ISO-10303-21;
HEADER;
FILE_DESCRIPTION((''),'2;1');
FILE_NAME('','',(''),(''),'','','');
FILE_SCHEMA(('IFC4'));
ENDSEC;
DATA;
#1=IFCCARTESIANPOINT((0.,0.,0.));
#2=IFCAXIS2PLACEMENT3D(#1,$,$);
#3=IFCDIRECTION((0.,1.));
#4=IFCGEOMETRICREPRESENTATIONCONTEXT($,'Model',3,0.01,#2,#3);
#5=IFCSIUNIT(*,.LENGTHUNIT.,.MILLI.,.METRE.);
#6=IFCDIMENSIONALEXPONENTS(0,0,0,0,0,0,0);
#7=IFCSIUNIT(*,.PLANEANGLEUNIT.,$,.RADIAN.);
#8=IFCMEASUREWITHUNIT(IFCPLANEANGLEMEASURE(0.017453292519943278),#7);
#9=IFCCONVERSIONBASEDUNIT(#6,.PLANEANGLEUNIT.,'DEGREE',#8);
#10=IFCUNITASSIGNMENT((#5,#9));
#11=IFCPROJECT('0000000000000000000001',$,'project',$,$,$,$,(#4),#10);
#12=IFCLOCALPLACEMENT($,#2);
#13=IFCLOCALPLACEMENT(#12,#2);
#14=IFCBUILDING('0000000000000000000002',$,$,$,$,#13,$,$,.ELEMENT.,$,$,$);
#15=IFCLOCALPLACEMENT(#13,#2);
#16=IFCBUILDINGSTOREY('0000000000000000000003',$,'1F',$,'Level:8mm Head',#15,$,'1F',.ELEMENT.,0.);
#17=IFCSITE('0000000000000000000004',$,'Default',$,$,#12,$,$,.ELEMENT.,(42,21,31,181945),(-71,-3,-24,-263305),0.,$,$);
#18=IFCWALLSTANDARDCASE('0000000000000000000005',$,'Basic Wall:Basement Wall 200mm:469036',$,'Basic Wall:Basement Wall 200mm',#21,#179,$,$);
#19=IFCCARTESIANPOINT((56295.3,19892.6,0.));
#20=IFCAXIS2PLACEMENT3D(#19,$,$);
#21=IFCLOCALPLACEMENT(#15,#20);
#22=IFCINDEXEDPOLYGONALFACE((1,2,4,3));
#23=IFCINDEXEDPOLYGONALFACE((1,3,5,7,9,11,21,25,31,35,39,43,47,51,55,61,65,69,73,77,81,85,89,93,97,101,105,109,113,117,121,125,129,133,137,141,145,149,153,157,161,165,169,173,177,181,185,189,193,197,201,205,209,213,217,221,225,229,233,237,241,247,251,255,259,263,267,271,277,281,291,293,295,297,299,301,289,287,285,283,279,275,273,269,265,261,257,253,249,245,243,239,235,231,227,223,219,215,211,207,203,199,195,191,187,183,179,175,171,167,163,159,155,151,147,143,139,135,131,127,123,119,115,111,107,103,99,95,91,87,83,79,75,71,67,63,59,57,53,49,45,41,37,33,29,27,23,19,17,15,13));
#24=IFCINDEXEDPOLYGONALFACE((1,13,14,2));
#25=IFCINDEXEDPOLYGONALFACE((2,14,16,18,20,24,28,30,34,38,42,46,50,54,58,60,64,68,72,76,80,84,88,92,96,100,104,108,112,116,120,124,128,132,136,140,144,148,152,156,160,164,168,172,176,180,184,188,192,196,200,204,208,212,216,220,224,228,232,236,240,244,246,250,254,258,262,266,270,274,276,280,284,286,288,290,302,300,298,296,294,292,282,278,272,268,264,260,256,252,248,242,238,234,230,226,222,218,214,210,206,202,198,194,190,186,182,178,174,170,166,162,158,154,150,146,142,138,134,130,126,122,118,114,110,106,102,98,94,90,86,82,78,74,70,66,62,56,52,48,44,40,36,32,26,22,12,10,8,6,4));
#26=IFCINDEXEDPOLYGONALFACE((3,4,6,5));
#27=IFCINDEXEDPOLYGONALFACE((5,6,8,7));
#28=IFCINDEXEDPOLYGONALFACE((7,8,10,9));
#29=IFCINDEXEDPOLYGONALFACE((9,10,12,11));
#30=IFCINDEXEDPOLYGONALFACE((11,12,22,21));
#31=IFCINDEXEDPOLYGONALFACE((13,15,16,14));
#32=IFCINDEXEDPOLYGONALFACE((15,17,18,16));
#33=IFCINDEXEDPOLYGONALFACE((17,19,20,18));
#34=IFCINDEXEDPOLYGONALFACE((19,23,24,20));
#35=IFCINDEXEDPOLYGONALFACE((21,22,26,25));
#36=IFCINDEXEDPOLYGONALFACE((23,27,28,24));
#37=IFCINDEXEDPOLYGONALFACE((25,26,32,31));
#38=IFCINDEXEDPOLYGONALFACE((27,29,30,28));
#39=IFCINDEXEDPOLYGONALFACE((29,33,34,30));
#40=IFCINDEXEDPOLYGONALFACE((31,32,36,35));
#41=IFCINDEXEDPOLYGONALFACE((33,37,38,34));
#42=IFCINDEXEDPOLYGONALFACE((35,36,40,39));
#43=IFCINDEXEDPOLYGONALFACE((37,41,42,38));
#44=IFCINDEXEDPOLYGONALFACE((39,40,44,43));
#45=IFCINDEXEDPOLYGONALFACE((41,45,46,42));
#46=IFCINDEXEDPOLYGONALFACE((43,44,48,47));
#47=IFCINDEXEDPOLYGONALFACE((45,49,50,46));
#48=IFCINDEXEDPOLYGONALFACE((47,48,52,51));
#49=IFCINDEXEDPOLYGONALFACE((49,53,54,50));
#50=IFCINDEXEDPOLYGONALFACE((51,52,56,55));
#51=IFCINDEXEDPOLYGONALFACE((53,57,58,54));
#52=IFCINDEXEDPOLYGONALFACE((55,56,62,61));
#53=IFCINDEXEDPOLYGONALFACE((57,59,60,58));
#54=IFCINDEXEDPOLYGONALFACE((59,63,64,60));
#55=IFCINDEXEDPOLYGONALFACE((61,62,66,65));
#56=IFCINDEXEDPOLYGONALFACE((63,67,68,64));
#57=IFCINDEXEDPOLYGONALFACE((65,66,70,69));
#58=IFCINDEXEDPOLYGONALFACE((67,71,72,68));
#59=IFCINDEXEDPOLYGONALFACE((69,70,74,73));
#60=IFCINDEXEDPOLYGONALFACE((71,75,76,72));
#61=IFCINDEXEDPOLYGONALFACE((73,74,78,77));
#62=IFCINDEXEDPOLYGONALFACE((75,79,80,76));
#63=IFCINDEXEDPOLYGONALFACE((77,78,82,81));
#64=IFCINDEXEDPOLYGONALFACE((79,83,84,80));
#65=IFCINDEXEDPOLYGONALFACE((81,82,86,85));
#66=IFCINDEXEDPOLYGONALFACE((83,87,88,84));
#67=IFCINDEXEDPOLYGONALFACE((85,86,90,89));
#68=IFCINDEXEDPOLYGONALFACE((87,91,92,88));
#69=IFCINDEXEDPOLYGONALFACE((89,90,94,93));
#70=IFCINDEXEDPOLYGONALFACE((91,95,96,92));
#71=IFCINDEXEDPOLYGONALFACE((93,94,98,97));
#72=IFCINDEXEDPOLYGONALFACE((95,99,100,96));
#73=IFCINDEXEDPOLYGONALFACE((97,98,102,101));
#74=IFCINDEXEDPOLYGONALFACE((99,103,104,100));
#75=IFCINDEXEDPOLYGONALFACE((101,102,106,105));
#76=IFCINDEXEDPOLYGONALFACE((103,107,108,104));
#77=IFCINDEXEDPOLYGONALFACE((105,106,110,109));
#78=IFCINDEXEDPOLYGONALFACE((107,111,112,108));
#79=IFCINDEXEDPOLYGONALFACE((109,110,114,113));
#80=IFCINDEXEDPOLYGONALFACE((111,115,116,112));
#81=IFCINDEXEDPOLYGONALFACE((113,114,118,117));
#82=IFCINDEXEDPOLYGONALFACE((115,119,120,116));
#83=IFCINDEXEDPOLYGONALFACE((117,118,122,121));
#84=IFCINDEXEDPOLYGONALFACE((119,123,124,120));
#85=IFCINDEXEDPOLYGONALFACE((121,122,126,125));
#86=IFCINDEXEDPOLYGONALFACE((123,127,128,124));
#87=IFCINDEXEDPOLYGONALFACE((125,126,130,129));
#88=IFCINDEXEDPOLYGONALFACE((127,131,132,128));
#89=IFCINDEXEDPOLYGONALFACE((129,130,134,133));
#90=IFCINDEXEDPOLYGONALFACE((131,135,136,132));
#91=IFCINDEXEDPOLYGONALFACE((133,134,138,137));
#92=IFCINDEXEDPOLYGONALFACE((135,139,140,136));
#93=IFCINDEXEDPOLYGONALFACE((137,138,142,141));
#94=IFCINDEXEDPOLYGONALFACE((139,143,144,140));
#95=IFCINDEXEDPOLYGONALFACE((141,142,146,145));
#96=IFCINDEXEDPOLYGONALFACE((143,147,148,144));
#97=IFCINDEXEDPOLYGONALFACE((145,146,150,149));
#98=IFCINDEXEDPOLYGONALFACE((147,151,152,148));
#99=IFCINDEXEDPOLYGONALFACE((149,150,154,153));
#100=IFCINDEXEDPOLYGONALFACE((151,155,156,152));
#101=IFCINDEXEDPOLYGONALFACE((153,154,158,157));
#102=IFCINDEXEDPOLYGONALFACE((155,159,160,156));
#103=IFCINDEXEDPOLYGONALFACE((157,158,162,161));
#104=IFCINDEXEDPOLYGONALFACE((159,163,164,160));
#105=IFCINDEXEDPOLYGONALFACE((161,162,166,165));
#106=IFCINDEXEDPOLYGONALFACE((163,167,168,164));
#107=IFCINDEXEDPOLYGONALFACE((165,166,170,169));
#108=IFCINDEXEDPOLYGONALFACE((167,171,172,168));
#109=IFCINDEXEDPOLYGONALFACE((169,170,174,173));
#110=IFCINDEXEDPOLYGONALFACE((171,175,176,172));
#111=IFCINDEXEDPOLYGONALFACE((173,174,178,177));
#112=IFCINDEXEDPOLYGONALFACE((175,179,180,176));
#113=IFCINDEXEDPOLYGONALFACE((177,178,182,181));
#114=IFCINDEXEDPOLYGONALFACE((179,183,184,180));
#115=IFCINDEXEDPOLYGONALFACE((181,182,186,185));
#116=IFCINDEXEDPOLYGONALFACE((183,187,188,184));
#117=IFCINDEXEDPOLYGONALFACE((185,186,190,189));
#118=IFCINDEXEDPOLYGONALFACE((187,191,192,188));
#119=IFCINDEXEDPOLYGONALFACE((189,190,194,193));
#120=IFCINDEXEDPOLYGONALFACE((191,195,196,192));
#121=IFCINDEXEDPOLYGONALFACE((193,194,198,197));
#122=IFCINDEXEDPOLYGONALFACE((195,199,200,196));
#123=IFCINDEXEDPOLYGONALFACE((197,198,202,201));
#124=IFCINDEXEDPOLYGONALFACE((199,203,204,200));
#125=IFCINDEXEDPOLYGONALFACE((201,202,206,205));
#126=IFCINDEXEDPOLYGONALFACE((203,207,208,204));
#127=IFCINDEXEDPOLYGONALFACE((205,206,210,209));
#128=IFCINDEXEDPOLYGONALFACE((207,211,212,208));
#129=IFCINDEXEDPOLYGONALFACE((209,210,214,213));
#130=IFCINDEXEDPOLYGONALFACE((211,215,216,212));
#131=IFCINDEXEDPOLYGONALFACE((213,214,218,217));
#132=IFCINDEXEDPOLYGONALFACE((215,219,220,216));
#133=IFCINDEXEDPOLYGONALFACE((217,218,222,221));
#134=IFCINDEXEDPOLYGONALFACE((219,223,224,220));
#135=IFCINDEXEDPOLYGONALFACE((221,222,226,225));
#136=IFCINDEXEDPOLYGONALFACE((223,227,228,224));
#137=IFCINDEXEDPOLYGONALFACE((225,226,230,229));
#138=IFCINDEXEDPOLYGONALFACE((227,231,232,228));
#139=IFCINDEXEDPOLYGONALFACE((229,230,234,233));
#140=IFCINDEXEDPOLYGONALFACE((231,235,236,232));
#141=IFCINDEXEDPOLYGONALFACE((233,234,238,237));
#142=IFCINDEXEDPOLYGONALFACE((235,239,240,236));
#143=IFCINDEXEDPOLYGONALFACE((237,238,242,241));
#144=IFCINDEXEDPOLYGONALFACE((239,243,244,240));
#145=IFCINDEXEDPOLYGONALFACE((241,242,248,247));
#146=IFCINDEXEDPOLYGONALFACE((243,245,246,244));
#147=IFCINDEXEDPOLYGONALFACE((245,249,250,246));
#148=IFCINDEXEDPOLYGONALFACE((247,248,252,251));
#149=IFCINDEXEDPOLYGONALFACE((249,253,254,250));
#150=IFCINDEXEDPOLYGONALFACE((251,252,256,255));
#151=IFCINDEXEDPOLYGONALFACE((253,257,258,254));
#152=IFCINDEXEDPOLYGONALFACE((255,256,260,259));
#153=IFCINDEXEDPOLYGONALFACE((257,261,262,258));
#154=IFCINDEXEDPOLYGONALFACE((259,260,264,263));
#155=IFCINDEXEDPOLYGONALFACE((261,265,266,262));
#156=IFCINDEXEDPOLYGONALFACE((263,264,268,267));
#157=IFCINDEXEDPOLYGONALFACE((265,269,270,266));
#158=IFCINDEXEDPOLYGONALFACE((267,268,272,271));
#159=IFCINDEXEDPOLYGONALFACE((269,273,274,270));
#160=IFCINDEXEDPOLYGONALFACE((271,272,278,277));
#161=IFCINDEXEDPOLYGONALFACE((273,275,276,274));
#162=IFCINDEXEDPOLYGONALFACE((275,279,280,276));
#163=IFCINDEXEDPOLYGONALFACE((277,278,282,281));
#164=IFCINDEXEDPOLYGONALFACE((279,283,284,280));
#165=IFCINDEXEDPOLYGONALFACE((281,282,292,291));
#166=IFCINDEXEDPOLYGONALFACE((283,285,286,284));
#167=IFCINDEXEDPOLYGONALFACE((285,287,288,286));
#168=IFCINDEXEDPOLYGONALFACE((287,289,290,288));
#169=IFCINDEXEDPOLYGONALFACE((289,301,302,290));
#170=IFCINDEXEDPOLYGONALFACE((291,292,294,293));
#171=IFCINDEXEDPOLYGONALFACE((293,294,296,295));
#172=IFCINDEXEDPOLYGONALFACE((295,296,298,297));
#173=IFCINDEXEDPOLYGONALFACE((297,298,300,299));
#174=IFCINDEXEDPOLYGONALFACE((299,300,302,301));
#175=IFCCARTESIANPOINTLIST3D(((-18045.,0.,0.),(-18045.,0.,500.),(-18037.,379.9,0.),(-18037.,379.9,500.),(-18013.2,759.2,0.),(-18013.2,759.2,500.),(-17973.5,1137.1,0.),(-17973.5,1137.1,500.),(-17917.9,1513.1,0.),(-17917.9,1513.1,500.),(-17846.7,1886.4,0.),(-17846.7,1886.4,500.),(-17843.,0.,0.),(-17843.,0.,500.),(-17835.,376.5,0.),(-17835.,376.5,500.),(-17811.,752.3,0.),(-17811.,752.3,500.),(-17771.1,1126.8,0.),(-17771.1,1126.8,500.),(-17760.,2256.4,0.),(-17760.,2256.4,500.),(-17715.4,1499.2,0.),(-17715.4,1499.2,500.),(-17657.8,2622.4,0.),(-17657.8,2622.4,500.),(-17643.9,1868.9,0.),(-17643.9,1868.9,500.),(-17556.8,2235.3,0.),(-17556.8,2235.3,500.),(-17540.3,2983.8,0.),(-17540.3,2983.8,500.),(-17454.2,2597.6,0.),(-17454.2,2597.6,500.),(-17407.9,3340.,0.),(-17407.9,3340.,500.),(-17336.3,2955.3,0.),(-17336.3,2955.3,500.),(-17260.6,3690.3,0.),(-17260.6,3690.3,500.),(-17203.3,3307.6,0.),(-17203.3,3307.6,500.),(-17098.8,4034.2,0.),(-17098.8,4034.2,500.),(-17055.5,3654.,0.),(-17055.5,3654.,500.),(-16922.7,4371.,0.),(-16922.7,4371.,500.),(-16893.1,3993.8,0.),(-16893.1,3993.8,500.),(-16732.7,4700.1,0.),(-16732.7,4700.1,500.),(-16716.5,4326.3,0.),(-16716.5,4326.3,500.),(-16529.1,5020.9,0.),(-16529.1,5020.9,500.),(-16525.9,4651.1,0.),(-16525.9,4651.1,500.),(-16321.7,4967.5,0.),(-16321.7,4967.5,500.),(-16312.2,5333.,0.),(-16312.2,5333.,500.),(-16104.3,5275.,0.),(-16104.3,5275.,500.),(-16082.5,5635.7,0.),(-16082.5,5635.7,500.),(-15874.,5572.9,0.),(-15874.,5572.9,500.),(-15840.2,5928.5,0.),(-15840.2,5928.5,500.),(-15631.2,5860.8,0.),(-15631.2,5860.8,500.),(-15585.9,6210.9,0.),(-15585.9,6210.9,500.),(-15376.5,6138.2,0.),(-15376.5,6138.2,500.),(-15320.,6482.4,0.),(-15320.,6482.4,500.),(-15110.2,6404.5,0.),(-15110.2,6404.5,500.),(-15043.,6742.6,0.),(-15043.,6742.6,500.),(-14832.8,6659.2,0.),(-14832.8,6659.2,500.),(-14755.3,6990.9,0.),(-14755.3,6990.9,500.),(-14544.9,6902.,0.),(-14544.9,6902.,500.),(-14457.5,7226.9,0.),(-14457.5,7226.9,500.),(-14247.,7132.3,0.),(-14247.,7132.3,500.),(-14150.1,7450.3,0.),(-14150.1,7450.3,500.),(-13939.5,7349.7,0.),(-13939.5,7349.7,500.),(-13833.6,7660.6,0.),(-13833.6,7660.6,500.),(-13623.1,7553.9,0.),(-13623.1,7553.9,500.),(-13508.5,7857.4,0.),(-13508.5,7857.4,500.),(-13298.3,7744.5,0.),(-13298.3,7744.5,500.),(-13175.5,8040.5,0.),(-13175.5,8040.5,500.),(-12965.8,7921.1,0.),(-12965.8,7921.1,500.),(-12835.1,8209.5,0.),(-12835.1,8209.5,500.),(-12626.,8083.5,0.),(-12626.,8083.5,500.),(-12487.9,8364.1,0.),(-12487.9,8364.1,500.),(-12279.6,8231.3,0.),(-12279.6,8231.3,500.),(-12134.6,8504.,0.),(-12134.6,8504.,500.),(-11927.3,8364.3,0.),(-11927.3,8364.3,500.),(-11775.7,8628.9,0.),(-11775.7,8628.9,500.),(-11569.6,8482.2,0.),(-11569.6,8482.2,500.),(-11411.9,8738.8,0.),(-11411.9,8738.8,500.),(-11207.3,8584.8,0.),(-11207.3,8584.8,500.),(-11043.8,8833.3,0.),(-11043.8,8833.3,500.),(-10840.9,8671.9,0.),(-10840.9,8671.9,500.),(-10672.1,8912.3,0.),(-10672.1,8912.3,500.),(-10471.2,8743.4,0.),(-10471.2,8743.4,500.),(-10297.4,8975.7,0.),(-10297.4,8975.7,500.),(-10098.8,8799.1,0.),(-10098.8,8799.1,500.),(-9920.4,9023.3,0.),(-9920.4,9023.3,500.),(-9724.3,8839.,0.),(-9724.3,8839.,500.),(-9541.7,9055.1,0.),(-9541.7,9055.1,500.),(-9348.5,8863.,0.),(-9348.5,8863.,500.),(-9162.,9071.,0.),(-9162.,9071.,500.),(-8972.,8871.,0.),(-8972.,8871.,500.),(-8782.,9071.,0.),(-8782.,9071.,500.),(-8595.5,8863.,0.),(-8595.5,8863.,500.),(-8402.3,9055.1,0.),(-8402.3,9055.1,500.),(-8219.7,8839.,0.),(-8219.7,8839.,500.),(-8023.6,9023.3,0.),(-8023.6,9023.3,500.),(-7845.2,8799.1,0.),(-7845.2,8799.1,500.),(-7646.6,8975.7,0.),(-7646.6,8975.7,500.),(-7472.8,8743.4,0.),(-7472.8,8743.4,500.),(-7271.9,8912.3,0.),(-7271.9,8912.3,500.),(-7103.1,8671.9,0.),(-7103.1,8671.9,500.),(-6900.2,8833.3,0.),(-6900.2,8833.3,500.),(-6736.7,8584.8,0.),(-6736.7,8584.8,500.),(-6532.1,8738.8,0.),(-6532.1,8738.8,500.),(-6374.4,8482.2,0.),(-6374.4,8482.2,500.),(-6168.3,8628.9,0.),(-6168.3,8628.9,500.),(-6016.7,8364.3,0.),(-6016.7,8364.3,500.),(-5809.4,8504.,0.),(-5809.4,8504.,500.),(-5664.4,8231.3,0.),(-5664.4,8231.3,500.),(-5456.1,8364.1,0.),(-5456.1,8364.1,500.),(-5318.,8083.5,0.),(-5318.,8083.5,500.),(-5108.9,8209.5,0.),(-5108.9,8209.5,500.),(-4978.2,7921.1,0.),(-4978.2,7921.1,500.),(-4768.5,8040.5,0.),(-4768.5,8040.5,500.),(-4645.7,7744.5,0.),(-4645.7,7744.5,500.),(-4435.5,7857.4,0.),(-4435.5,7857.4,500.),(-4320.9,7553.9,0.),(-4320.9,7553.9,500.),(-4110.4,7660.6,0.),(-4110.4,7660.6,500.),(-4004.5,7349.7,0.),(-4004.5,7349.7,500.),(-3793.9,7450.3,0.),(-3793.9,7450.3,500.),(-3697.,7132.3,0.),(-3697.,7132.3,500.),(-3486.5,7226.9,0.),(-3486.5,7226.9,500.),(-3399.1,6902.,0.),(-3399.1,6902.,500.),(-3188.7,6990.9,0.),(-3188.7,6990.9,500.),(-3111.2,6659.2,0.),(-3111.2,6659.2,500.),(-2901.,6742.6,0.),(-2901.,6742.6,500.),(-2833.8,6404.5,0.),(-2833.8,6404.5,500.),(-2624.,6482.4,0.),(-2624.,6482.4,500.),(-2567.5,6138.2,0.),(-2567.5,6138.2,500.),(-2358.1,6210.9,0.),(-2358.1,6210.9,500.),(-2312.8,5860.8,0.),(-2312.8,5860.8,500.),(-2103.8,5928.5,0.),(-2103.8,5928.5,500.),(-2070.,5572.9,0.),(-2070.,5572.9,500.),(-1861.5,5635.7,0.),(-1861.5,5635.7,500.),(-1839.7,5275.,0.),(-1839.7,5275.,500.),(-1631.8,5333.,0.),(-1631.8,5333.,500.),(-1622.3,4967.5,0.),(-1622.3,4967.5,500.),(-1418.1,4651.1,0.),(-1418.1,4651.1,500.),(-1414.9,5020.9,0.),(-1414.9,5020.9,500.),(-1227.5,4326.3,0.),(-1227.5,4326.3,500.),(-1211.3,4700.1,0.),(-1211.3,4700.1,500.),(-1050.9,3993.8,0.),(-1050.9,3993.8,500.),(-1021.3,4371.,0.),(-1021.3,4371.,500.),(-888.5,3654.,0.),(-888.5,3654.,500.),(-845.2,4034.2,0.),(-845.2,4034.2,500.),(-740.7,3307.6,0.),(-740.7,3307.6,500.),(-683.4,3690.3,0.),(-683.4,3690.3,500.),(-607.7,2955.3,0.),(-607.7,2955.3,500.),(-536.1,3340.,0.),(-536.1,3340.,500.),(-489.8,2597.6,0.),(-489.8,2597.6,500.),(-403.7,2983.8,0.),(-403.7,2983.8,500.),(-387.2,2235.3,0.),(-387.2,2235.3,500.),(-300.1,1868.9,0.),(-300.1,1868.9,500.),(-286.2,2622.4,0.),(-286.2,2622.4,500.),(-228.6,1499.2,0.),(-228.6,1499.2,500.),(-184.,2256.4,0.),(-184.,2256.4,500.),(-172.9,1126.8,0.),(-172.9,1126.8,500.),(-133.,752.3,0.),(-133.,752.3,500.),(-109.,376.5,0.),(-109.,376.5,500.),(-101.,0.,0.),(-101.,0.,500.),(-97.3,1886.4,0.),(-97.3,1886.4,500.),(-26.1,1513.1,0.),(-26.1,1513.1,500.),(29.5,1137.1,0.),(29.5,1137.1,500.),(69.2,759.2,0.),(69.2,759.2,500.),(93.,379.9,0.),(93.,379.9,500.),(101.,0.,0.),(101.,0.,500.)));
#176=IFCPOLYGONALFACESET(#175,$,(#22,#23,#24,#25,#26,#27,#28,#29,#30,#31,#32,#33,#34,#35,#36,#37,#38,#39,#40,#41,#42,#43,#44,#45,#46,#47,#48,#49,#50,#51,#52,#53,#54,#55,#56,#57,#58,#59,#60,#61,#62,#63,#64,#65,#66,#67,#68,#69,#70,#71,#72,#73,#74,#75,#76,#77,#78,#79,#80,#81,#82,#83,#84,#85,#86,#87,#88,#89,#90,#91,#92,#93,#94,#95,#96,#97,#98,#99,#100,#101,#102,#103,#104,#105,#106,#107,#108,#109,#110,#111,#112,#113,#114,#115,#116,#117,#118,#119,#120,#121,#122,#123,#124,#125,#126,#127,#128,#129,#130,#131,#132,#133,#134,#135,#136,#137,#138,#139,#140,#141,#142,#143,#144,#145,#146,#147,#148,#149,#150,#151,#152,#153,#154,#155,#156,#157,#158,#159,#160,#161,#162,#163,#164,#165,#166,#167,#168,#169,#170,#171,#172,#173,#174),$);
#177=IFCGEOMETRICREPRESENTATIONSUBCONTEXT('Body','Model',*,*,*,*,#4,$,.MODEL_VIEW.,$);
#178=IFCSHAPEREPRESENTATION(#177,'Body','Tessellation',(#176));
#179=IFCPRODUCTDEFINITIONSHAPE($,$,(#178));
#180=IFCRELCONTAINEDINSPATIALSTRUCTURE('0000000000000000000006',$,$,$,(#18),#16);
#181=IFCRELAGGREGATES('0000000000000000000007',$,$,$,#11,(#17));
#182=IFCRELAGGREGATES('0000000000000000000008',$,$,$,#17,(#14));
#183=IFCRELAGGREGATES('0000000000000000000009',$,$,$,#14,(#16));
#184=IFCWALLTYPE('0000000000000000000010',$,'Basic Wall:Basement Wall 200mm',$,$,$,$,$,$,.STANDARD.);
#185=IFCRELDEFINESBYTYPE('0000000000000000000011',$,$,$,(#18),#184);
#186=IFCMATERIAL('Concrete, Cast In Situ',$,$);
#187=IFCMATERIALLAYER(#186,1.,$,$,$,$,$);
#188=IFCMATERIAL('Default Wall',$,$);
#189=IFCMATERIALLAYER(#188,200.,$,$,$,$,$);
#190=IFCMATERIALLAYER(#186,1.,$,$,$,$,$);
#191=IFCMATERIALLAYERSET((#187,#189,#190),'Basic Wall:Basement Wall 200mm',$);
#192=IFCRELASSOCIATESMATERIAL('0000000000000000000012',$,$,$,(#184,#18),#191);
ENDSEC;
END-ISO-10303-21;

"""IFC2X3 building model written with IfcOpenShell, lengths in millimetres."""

from ifc_helpers import new_model, entity, si_unit, converted_unit, direction, frame, frame_2d, origin, place, context, subcontext, project, spatial, polyline, circle_curve, parameter, trimmed, segment, composite_curve, outline, extrude, material, layer, layer_set, layer_usage, type_object, element, save


model = new_model("IFC2X3")

# Units and contexts
model_context = context("Model", 3, precision=0.01, world=origin(), true_north=direction((0.0, 1.0)))
body_context = subcontext(model_context, "Body", "Model", "MODEL_VIEW")
ifc_project = project(units=[si_unit("LENGTHUNIT", "METRE", prefix="MILLI"), converted_unit("PLANEANGLEUNIT", "DEGREE", entity("IfcPlaneAngleMeasure", 0.017453292519943278), si_unit("PLANEANGLEUNIT", "RADIAN"), dimensions=[0, 0, 0, 0, 0, 0, 0])], contexts=[model_context])

# Site, building, storey
site_placement = place(None, origin())
site = spatial("IfcSite", under=ifc_project, at=site_placement, Name="Default", CompositionType="ELEMENT", RefLatitude=(42, 21, 31, 181945), RefLongitude=(-71, -3, -24, -263305), RefElevation=0.0)
building_placement = place(site_placement, origin())
building = spatial("IfcBuilding", under=site, at=building_placement, CompositionType="ELEMENT")
storey_placement = place(building_placement, origin())
storey = spatial("IfcBuildingStorey", under=building, at=storey_placement, Name="1F", ObjectType="Level:8mm Head", LongName="1F", CompositionType="ELEMENT", Elevation=0.0)

# Shared definitions
ifc_material_1 = material(Name="Default Wall")

# Wall
ifc_material_2 = material(Name="Concrete, Cast In Situ")
ifc_layer_1 = layer(ifc_material_2, 1.0)
ifc_layer_2 = layer(ifc_material_1, 200.0)
ifc_layer_3 = layer(ifc_material_2, 1.0)
ifc_layer_set_1 = layer_set([ifc_layer_1, ifc_layer_2, ifc_layer_3], Name="Basic Wall:Basement Wall 200mm")
ifc_layer_usage_1 = layer_usage(ifc_layer_set_1, "AXIS2", "NEGATIVE", 101.0)
wall_type_1 = type_object("IfcWallType", Name="Basic Wall:Basement Wall 200mm", PredefinedType="STANDARD", material=ifc_layer_set_1)
wall_1_placement = place(storey_placement, frame((56295.3, 19892.6, 0.0)))
element("IfcWallStandardCase", 1, at=wall_1_placement, inside=storey, type_object=wall_type_1, material=ifc_layer_usage_1, Name="Basic Wall:Basement Wall 200mm:469036", ObjectType="Basic Wall:Basement Wall 200mm", context=body_context, shape_type="SweptSolid", body=[
    extrude(outline(composite_curve([segment(trimmed(circle_curve(frame_2d((-8972.0, 0.0), x_axis=(1.0, 0.0)), 8871.0), [parameter(0.0)], [parameter(180.0)], True, "PARAMETER"), False, "CONTINUOUS"), segment(polyline([(-101.0, 0.0), (101.0, 0.0)]), True, "CONTINUOUS"), segment(trimmed(circle_curve(frame_2d((-8972.0, 0.0), x_axis=(1.0, 0.0)), 9073.0), [parameter(0.0)], [parameter(180.0)], True, "PARAMETER"), True, "CONTINUOUS"), segment(polyline([(-18045.0, 0.0), (-17843.0, 0.0)]), True, "CONTINUOUS")], self_intersect=False)), origin(), (0.0, 0.0, 1.0), 500.0),
])

save(model, "model.ifc")
